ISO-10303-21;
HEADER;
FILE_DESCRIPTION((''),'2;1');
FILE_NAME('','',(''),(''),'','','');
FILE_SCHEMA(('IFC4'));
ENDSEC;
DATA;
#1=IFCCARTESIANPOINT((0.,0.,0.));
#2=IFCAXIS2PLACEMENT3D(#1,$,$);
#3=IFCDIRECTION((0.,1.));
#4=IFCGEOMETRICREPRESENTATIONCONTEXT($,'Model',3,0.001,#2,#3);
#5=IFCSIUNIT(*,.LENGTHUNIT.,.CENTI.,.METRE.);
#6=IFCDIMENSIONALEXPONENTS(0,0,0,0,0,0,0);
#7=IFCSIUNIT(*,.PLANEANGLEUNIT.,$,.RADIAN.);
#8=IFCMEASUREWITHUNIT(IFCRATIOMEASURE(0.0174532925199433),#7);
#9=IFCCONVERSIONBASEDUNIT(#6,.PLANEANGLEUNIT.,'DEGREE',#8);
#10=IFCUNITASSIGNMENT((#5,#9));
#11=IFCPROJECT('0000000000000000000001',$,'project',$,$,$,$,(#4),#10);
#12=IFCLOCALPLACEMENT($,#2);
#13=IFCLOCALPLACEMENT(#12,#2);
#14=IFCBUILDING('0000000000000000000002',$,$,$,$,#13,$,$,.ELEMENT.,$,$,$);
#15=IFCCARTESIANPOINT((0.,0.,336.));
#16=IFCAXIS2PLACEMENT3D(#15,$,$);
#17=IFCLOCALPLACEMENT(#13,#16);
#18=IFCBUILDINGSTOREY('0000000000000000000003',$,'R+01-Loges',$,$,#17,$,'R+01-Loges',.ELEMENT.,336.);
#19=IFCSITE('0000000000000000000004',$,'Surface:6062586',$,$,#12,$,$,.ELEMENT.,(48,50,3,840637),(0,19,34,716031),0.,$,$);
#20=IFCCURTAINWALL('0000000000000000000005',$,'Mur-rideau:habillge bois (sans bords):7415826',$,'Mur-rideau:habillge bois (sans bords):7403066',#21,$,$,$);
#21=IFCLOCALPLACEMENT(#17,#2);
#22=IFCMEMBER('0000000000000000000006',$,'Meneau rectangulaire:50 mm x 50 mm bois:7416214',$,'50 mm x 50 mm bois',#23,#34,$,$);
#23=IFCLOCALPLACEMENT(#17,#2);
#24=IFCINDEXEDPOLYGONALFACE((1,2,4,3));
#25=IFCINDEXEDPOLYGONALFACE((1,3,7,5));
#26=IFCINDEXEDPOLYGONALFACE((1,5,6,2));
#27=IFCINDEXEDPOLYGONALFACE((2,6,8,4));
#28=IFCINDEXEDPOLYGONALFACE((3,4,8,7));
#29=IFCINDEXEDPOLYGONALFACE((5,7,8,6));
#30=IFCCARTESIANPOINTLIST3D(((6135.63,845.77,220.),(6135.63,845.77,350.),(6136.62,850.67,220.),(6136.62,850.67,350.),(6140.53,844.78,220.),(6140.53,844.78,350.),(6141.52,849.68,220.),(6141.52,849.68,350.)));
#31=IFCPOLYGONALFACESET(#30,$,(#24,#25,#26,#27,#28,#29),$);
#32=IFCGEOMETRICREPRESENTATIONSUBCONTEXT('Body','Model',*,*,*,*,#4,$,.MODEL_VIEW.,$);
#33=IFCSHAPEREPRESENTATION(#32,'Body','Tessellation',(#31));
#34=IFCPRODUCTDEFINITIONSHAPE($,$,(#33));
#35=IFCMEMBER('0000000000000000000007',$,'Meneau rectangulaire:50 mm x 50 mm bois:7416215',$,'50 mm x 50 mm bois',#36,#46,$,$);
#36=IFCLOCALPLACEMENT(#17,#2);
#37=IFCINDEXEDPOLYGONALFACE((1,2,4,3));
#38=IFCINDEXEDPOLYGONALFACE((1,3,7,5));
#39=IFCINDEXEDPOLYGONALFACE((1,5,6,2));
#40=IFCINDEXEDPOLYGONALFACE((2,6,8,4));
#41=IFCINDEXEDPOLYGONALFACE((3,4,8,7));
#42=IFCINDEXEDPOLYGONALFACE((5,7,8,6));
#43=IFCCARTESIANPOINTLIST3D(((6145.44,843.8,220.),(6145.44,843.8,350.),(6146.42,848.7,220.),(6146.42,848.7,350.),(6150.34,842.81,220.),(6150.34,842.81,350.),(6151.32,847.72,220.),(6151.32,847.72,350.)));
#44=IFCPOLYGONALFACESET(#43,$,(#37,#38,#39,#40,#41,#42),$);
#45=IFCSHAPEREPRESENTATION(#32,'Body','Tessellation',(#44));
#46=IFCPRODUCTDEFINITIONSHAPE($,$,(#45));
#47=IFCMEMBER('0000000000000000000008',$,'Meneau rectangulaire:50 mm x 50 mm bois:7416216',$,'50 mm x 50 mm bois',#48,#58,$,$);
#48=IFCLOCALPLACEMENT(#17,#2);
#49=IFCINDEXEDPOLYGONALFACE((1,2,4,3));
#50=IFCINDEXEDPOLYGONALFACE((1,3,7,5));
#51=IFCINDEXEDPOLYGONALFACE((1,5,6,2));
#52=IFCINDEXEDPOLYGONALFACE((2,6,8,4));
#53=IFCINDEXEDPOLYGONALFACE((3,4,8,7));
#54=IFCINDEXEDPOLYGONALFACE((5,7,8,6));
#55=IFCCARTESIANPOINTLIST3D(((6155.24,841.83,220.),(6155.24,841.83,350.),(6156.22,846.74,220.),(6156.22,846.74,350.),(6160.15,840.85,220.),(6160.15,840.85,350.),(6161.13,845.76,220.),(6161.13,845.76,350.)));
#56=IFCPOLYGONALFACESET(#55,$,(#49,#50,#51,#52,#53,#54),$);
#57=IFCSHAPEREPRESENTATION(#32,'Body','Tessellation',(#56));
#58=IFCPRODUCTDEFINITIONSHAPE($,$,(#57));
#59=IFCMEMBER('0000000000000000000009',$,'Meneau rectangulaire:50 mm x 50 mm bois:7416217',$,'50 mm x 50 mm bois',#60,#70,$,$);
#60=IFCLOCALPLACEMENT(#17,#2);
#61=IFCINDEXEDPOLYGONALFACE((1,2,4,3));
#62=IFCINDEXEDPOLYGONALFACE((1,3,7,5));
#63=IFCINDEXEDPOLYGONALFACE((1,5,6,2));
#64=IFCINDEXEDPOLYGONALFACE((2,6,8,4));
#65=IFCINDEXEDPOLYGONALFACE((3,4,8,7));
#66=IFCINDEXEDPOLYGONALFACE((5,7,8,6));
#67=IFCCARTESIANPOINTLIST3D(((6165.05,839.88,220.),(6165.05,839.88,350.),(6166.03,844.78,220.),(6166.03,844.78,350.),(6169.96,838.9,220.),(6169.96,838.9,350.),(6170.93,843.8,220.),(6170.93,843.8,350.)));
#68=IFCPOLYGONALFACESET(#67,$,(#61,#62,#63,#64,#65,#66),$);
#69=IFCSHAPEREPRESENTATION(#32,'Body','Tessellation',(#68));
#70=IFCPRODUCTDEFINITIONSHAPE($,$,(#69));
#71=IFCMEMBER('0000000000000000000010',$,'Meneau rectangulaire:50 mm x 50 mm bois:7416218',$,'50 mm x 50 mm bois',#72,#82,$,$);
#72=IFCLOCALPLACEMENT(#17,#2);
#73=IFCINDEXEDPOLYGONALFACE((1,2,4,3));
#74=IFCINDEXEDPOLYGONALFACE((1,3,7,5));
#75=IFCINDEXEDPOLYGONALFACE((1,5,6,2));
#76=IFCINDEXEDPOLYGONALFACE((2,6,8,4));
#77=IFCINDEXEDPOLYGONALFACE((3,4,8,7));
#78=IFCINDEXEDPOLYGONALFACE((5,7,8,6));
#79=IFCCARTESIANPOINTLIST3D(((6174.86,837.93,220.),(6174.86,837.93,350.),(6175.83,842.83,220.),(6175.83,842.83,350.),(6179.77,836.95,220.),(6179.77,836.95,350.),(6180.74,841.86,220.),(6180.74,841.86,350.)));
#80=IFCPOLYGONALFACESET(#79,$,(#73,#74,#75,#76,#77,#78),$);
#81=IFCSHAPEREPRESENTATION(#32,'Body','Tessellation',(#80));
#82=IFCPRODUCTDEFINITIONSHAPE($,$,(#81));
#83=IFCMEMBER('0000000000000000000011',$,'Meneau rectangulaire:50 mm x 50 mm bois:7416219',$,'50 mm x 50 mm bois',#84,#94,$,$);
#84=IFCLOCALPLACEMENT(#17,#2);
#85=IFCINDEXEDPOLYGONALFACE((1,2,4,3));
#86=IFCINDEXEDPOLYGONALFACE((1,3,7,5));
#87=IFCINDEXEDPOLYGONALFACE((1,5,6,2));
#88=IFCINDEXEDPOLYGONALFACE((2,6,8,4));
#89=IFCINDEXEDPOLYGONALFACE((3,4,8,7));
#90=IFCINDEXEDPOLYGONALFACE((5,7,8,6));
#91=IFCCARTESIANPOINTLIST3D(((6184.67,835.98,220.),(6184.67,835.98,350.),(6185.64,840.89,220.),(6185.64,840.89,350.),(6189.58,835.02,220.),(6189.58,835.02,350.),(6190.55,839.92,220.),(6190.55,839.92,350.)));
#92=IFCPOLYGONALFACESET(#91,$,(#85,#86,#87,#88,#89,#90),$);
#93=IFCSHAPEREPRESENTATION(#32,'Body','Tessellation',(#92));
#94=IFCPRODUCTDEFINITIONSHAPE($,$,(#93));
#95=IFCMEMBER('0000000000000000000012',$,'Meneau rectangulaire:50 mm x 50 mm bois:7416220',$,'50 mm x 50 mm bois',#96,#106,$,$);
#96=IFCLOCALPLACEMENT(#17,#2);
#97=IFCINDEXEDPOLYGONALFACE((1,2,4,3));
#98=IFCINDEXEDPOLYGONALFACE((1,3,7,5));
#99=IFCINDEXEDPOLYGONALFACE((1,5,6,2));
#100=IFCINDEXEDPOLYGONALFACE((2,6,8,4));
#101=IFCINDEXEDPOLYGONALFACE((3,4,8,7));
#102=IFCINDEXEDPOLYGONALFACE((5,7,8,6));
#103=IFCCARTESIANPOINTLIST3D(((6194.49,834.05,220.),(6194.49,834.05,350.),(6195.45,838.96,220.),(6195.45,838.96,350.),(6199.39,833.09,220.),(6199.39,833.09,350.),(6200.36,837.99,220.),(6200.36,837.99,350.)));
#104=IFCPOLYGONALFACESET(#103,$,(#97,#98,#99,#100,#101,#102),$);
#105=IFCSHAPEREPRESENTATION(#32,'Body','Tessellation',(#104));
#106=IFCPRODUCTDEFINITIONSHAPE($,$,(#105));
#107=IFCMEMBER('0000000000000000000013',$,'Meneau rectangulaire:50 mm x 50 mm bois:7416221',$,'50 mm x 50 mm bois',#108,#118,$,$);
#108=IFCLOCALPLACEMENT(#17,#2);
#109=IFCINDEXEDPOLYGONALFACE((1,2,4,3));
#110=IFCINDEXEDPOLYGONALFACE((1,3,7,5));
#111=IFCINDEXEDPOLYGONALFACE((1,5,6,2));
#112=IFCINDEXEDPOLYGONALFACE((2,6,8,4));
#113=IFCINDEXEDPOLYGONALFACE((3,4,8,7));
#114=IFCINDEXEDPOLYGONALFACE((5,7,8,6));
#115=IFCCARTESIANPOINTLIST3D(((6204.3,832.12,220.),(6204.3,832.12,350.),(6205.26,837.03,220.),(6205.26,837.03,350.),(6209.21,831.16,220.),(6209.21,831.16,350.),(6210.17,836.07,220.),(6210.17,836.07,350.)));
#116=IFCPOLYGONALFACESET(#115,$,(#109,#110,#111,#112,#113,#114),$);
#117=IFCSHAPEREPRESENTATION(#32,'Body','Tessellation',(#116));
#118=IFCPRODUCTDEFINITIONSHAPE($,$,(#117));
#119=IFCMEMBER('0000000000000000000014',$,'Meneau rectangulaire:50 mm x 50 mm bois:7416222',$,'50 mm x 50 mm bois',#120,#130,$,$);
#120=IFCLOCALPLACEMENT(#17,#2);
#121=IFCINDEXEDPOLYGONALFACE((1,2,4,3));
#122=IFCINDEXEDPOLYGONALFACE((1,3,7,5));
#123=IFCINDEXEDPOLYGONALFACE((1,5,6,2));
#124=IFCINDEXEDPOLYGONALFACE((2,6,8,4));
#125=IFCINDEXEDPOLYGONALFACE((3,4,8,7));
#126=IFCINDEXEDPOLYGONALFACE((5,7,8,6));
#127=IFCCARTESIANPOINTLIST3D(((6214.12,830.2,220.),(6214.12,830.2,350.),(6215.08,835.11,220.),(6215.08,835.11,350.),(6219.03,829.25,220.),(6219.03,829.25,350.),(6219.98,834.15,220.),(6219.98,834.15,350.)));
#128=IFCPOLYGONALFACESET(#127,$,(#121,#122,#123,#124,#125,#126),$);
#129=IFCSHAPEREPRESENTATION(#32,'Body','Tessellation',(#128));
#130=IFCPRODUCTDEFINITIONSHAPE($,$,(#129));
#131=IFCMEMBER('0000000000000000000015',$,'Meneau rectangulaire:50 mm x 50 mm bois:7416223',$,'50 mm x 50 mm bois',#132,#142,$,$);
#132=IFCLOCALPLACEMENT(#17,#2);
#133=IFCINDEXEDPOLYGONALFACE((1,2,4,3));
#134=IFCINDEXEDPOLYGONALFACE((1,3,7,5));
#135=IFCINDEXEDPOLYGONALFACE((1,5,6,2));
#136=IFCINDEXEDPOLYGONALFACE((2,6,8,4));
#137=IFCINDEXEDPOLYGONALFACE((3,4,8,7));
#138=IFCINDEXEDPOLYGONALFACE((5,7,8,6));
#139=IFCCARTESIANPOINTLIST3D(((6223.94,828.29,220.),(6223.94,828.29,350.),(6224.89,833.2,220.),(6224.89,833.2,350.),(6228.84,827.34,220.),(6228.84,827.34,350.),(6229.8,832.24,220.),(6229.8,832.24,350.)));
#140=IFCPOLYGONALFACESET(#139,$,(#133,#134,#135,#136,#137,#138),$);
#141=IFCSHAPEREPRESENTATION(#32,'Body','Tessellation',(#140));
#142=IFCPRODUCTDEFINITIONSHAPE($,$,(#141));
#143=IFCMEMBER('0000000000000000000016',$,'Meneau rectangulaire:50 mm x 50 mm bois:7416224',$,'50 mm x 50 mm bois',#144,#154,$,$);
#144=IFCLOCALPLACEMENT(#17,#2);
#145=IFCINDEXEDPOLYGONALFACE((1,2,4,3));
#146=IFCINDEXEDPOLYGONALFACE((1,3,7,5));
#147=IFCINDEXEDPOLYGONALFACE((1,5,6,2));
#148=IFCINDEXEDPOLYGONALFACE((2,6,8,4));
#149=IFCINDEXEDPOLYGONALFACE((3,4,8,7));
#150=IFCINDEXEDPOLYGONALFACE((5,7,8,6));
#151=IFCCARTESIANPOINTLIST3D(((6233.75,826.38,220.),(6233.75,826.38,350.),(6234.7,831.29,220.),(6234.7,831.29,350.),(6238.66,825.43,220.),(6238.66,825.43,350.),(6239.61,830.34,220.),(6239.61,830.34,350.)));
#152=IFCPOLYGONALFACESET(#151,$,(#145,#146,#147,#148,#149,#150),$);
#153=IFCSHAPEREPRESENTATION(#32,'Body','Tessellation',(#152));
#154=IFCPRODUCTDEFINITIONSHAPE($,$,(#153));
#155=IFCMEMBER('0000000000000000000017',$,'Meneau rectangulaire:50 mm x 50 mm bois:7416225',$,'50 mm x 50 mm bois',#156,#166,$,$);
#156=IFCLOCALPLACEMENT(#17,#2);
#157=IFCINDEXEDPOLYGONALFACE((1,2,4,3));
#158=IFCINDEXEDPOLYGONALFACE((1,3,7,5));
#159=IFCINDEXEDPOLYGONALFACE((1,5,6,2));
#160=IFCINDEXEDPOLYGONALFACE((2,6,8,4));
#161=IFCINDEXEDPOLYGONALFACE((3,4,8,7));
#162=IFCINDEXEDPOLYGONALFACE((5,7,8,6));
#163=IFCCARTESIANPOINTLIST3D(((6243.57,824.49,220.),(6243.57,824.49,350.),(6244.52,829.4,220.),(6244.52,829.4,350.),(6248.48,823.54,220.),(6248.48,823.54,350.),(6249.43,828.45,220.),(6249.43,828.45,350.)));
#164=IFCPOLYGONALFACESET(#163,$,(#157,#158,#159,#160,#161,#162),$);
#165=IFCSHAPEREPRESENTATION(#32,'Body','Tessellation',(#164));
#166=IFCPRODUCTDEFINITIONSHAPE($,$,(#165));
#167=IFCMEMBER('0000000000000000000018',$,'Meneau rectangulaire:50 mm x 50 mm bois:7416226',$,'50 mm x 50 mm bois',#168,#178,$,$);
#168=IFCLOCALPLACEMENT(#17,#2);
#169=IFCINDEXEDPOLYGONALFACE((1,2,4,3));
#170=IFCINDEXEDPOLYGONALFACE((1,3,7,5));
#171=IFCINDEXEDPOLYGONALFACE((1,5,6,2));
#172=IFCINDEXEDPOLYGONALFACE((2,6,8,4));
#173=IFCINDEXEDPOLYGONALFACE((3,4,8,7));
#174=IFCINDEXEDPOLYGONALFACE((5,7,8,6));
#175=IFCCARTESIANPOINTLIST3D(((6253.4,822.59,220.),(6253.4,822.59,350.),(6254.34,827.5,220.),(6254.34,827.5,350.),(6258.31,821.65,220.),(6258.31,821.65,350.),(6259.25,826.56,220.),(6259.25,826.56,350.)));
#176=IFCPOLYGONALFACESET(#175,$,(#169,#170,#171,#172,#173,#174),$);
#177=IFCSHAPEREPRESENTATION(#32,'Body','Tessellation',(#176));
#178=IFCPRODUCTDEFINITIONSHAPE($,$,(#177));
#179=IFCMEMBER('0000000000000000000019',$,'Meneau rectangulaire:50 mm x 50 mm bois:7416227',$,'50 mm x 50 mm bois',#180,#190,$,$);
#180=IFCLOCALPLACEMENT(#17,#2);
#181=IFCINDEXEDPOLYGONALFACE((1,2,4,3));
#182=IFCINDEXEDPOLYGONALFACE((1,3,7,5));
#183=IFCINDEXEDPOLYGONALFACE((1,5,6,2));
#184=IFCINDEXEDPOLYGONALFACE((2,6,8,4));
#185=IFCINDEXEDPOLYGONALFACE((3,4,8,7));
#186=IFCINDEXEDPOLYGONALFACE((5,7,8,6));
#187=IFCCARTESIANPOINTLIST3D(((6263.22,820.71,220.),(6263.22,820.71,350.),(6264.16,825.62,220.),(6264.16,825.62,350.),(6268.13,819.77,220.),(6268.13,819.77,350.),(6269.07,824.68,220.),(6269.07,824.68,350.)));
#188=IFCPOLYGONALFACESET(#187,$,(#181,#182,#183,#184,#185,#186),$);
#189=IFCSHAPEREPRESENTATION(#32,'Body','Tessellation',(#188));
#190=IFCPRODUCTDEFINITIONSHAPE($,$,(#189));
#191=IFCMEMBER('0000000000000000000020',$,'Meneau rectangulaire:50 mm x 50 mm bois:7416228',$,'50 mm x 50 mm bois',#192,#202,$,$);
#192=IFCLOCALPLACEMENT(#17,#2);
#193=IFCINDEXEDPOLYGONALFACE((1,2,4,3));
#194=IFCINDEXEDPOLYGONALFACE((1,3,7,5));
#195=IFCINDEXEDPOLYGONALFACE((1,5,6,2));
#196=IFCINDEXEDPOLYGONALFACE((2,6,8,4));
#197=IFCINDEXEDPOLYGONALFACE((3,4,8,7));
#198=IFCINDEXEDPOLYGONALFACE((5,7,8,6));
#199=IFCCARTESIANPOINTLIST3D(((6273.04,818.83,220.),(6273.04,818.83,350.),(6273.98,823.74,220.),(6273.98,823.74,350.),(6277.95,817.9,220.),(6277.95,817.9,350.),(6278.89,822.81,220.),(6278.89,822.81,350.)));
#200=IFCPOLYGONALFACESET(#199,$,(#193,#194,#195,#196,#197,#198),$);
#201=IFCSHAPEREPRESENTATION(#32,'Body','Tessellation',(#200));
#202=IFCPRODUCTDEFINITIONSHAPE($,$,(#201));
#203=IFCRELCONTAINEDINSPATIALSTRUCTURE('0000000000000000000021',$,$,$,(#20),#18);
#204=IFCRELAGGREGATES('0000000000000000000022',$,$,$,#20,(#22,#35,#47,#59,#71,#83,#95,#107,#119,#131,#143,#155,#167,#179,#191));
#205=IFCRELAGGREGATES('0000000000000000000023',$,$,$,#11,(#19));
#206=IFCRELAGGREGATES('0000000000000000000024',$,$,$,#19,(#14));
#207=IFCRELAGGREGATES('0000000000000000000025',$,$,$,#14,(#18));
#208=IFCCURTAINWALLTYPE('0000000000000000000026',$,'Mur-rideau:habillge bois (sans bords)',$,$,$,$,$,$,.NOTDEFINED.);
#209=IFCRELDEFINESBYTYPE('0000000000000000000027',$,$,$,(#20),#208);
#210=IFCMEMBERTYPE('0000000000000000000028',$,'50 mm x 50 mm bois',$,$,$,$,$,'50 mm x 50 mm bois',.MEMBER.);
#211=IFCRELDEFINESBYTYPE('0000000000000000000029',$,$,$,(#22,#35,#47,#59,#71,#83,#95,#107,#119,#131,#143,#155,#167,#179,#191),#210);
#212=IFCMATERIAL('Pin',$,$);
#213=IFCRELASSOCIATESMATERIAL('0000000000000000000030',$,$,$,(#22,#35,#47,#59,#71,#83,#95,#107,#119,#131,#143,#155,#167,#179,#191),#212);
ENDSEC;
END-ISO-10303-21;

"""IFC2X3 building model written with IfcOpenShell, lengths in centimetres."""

from ifc_helpers import new_model, entity, si_unit, converted_unit, direction, frame, origin, origin_2d_with_axis, place, context, subcontext, project, spatial, rectangle, extrude, source, transform, mapped, material, type_object, type_shapes, element, aggregate, save


model = new_model("IFC2X3")

# Units and contexts
model_context = context("Model", 3, precision=0.001, world=origin(), true_north=direction((0.0, 1.0)))
body_context = subcontext(model_context, "Body", "Model", "MODEL_VIEW")
ifc_project = project(units=[si_unit("LENGTHUNIT", "METRE", prefix="CENTI"), converted_unit("PLANEANGLEUNIT", "DEGREE", entity("IfcRatioMeasure", 0.0174532925199433), si_unit("PLANEANGLEUNIT", "RADIAN"), dimensions=[0, 0, 0, 0, 0, 0, 0])], contexts=[model_context])

# Site, building, storey
site_placement = place(None, origin())
site = spatial("IfcSite", under=ifc_project, at=site_placement, Name="Surface:6062586", CompositionType="ELEMENT", RefLatitude=(48, 50, 3, 840637), RefLongitude=(0, 19, 34, 716031), RefElevation=0.0)
building_placement = place(site_placement, origin())
building = spatial("IfcBuilding", under=site, at=building_placement, CompositionType="ELEMENT")
storey_placement = place(building_placement, frame((0.0, 0.0, 336.0)))
storey = spatial("IfcBuildingStorey", under=building, at=storey_placement, Name="R+01-Loges", LongName="R+01-Loges", CompositionType="ELEMENT", Elevation=336.0)

# Curtain wall, members
curtain_wall_type = type_object("IfcCurtainWallType", Name="Mur-rideau:habillge bois (sans bords)", PredefinedType="NOTDEFINED")
curtain_wall_placement = place(storey_placement, frame((0.0, 0.0, -336.0)))
curtain_wall = element("IfcCurtainWall", 1, at=curtain_wall_placement, inside=storey, type_object=curtain_wall_type, Name="Mur-rideau:habillge bois (sans bords):7415826", ObjectType="Mur-rideau:habillge bois (sans bords):7403066")
ifc_material = material(Name="Pin")
member_type = type_object("IfcMemberType", Name="50 mm x 50 mm bois", ElementType="50 mm x 50 mm bois", PredefinedType="MEMBER")
shared_shape = source(origin(), body_context, "Body", "SweptSolid", [
    extrude(rectangle(XDim=5.0, YDim=5.0, at=origin_2d_with_axis()), frame((0.0, 0.0, -130.0), z_axis=(0.0, 0.0, 1.0), x_axis=(0.0, -1.0, 0.0)), (0.0, 0.0, 1.0), 130.0),
])
type_shapes(member_type, [shared_shape])
member_1_placement = place(storey_placement, frame((6138.58, 847.72, 220.0), z_axis=(0.0, 0.0, -1.0), x_axis=(0.98036, -0.197214, 0.0)))
member_1 = element("IfcMember", 2, at=member_1_placement, type_object=member_type, material=ifc_material, Name="Meneau rectangulaire:50 mm x 50 mm bois:7416214", ObjectType="50 mm x 50 mm bois", context=body_context, shape_type="MappedRepresentation", body=[
    mapped(shared_shape, transform((0.0, 0.0, 0.0), scale=1.0)),
])
member_2_placement = place(storey_placement, frame((6148.38, 845.76, 220.0), z_axis=(0.0, 0.0, -1.0), x_axis=(0.980505, -0.196493, 0.0)))
member_2 = element("IfcMember", 3, at=member_2_placement, type_object=member_type, material=ifc_material, Name="Meneau rectangulaire:50 mm x 50 mm bois:7416215", ObjectType="50 mm x 50 mm bois", context=body_context, shape_type="MappedRepresentation", body=[
    mapped(shared_shape, transform((0.0, 0.0, 0.0), scale=1.0)),
])
member_3_placement = place(storey_placement, frame((6158.19, 843.79, 220.0), z_axis=(0.0, 0.0, -1.0), x_axis=(0.98065, -0.195771, 0.0)))
member_3 = element("IfcMember", 4, at=member_3_placement, type_object=member_type, material=ifc_material, Name="Meneau rectangulaire:50 mm x 50 mm bois:7416216", ObjectType="50 mm x 50 mm bois", context=body_context, shape_type="MappedRepresentation", body=[
    mapped(shared_shape, transform((0.0, 0.0, 0.0), scale=1.0)),
])
member_4_placement = place(storey_placement, frame((6167.99, 841.84, 220.0), z_axis=(0.0, 0.0, -1.0), x_axis=(0.980793, -0.19505, 0.0)))
member_4 = element("IfcMember", 5, at=member_4_placement, type_object=member_type, material=ifc_material, Name="Meneau rectangulaire:50 mm x 50 mm bois:7416217", ObjectType="50 mm x 50 mm bois", context=body_context, shape_type="MappedRepresentation", body=[
    mapped(shared_shape, transform((0.0, 0.0, 0.0), scale=1.0)),
])
member_5_placement = place(storey_placement, frame((6177.8, 839.89, 220.0), z_axis=(0.0, 0.0, -1.0), x_axis=(0.980937, -0.194328, 0.0)))
member_5 = element("IfcMember", 6, at=member_5_placement, type_object=member_type, material=ifc_material, Name="Meneau rectangulaire:50 mm x 50 mm bois:7416218", ObjectType="50 mm x 50 mm bois", context=body_context, shape_type="MappedRepresentation", body=[
    mapped(shared_shape, transform((0.0, 0.0, 0.0), scale=1.0)),
])
member_6_placement = place(storey_placement, frame((6187.61, 837.95, 220.0), z_axis=(0.0, 0.0, -1.0), x_axis=(0.981079, -0.193606, 0.0)))
member_6 = element("IfcMember", 7, at=member_6_placement, type_object=member_type, material=ifc_material, Name="Meneau rectangulaire:50 mm x 50 mm bois:7416219", ObjectType="50 mm x 50 mm bois", context=body_context, shape_type="MappedRepresentation", body=[
    mapped(shared_shape, transform((0.0, 0.0, 0.0), scale=1.0)),
])
member_7_placement = place(storey_placement, frame((6197.42, 836.02, 220.0), z_axis=(0.0, 0.0, -1.0), x_axis=(0.981222, -0.192884, 0.0)))
member_7 = element("IfcMember", 8, at=member_7_placement, type_object=member_type, material=ifc_material, Name="Meneau rectangulaire:50 mm x 50 mm bois:7416220", ObjectType="50 mm x 50 mm bois", context=body_context, shape_type="MappedRepresentation", body=[
    mapped(shared_shape, transform((0.0, 0.0, 0.0), scale=1.0)),
])
member_8_placement = place(storey_placement, frame((6207.24, 834.1, 220.0), z_axis=(0.0, 0.0, -1.0), x_axis=(0.981363, -0.192162, 0.0)))
member_8 = element("IfcMember", 9, at=member_8_placement, type_object=member_type, material=ifc_material, Name="Meneau rectangulaire:50 mm x 50 mm bois:7416221", ObjectType="50 mm x 50 mm bois", context=body_context, shape_type="MappedRepresentation", body=[
    mapped(shared_shape, transform((0.0, 0.0, 0.0), scale=1.0)),
])
member_9_placement = place(storey_placement, frame((6217.05, 832.18, 220.0), z_axis=(0.0, 0.0, -1.0), x_axis=(0.981504, -0.19144, 0.0)))
member_9 = element("IfcMember", 10, at=member_9_placement, type_object=member_type, material=ifc_material, Name="Meneau rectangulaire:50 mm x 50 mm bois:7416222", ObjectType="50 mm x 50 mm bois", context=body_context, shape_type="MappedRepresentation", body=[
    mapped(shared_shape, transform((0.0, 0.0, 0.0), scale=1.0)),
])
member_10_placement = place(storey_placement, frame((6226.87, 830.27, 220.0), z_axis=(0.0, 0.0, -1.0), x_axis=(0.981645, -0.190718, 0.0)))
member_10 = element("IfcMember", 11, at=member_10_placement, type_object=member_type, material=ifc_material, Name="Meneau rectangulaire:50 mm x 50 mm bois:7416223", ObjectType="50 mm x 50 mm bois", context=body_context, shape_type="MappedRepresentation", body=[
    mapped(shared_shape, transform((0.0, 0.0, 0.0), scale=1.0)),
])
member_11_placement = place(storey_placement, frame((6236.68, 828.36, 220.0), z_axis=(0.0, 0.0, -1.0), x_axis=(0.981785, -0.189995, 0.0)))
member_11 = element("IfcMember", 12, at=member_11_placement, type_object=member_type, material=ifc_material, Name="Meneau rectangulaire:50 mm x 50 mm bois:7416224", ObjectType="50 mm x 50 mm bois", context=body_context, shape_type="MappedRepresentation", body=[
    mapped(shared_shape, transform((0.0, 0.0, 0.0), scale=1.0)),
])
member_12_placement = place(storey_placement, frame((6246.5, 826.47, 220.0), z_axis=(0.0, 0.0, -1.0), x_axis=(0.981925, -0.189273, 0.0)))
member_12 = element("IfcMember", 13, at=member_12_placement, type_object=member_type, material=ifc_material, Name="Meneau rectangulaire:50 mm x 50 mm bois:7416225", ObjectType="50 mm x 50 mm bois", context=body_context, shape_type="MappedRepresentation", body=[
    mapped(shared_shape, transform((0.0, 0.0, 0.0), scale=1.0)),
])
member_13_placement = place(storey_placement, frame((6256.32, 824.58, 220.0), z_axis=(0.0, 0.0, -1.0), x_axis=(0.982064, -0.18855, 0.0)))
member_13 = element("IfcMember", 14, at=member_13_placement, type_object=member_type, material=ifc_material, Name="Meneau rectangulaire:50 mm x 50 mm bois:7416226", ObjectType="50 mm x 50 mm bois", context=body_context, shape_type="MappedRepresentation", body=[
    mapped(shared_shape, transform((0.0, 0.0, 0.0), scale=1.0)),
])
member_14_placement = place(storey_placement, frame((6266.14, 822.7, 220.0), z_axis=(0.0, 0.0, -1.0), x_axis=(0.982202, -0.187828, 0.0)))
member_14 = element("IfcMember", 15, at=member_14_placement, type_object=member_type, material=ifc_material, Name="Meneau rectangulaire:50 mm x 50 mm bois:7416227", ObjectType="50 mm x 50 mm bois", context=body_context, shape_type="MappedRepresentation", body=[
    mapped(shared_shape, transform((0.0, 0.0, 0.0), scale=1.0)),
])
member_15_placement = place(storey_placement, frame((6275.97, 820.82, 220.0), z_axis=(0.0, 0.0, -1.0), x_axis=(0.98234, -0.187105, 0.0)))
member_15 = element("IfcMember", 16, at=member_15_placement, type_object=member_type, material=ifc_material, Name="Meneau rectangulaire:50 mm x 50 mm bois:7416228", ObjectType="50 mm x 50 mm bois", context=body_context, shape_type="MappedRepresentation", body=[
    mapped(shared_shape, transform((0.0, 0.0, 0.0), scale=1.0)),
])
aggregate(curtain_wall, [member_1, member_2, member_3, member_4, member_5, member_6, member_7, member_8, member_9, member_10, member_11, member_12, member_13, member_14, member_15])

save(model, "model.ifc")
